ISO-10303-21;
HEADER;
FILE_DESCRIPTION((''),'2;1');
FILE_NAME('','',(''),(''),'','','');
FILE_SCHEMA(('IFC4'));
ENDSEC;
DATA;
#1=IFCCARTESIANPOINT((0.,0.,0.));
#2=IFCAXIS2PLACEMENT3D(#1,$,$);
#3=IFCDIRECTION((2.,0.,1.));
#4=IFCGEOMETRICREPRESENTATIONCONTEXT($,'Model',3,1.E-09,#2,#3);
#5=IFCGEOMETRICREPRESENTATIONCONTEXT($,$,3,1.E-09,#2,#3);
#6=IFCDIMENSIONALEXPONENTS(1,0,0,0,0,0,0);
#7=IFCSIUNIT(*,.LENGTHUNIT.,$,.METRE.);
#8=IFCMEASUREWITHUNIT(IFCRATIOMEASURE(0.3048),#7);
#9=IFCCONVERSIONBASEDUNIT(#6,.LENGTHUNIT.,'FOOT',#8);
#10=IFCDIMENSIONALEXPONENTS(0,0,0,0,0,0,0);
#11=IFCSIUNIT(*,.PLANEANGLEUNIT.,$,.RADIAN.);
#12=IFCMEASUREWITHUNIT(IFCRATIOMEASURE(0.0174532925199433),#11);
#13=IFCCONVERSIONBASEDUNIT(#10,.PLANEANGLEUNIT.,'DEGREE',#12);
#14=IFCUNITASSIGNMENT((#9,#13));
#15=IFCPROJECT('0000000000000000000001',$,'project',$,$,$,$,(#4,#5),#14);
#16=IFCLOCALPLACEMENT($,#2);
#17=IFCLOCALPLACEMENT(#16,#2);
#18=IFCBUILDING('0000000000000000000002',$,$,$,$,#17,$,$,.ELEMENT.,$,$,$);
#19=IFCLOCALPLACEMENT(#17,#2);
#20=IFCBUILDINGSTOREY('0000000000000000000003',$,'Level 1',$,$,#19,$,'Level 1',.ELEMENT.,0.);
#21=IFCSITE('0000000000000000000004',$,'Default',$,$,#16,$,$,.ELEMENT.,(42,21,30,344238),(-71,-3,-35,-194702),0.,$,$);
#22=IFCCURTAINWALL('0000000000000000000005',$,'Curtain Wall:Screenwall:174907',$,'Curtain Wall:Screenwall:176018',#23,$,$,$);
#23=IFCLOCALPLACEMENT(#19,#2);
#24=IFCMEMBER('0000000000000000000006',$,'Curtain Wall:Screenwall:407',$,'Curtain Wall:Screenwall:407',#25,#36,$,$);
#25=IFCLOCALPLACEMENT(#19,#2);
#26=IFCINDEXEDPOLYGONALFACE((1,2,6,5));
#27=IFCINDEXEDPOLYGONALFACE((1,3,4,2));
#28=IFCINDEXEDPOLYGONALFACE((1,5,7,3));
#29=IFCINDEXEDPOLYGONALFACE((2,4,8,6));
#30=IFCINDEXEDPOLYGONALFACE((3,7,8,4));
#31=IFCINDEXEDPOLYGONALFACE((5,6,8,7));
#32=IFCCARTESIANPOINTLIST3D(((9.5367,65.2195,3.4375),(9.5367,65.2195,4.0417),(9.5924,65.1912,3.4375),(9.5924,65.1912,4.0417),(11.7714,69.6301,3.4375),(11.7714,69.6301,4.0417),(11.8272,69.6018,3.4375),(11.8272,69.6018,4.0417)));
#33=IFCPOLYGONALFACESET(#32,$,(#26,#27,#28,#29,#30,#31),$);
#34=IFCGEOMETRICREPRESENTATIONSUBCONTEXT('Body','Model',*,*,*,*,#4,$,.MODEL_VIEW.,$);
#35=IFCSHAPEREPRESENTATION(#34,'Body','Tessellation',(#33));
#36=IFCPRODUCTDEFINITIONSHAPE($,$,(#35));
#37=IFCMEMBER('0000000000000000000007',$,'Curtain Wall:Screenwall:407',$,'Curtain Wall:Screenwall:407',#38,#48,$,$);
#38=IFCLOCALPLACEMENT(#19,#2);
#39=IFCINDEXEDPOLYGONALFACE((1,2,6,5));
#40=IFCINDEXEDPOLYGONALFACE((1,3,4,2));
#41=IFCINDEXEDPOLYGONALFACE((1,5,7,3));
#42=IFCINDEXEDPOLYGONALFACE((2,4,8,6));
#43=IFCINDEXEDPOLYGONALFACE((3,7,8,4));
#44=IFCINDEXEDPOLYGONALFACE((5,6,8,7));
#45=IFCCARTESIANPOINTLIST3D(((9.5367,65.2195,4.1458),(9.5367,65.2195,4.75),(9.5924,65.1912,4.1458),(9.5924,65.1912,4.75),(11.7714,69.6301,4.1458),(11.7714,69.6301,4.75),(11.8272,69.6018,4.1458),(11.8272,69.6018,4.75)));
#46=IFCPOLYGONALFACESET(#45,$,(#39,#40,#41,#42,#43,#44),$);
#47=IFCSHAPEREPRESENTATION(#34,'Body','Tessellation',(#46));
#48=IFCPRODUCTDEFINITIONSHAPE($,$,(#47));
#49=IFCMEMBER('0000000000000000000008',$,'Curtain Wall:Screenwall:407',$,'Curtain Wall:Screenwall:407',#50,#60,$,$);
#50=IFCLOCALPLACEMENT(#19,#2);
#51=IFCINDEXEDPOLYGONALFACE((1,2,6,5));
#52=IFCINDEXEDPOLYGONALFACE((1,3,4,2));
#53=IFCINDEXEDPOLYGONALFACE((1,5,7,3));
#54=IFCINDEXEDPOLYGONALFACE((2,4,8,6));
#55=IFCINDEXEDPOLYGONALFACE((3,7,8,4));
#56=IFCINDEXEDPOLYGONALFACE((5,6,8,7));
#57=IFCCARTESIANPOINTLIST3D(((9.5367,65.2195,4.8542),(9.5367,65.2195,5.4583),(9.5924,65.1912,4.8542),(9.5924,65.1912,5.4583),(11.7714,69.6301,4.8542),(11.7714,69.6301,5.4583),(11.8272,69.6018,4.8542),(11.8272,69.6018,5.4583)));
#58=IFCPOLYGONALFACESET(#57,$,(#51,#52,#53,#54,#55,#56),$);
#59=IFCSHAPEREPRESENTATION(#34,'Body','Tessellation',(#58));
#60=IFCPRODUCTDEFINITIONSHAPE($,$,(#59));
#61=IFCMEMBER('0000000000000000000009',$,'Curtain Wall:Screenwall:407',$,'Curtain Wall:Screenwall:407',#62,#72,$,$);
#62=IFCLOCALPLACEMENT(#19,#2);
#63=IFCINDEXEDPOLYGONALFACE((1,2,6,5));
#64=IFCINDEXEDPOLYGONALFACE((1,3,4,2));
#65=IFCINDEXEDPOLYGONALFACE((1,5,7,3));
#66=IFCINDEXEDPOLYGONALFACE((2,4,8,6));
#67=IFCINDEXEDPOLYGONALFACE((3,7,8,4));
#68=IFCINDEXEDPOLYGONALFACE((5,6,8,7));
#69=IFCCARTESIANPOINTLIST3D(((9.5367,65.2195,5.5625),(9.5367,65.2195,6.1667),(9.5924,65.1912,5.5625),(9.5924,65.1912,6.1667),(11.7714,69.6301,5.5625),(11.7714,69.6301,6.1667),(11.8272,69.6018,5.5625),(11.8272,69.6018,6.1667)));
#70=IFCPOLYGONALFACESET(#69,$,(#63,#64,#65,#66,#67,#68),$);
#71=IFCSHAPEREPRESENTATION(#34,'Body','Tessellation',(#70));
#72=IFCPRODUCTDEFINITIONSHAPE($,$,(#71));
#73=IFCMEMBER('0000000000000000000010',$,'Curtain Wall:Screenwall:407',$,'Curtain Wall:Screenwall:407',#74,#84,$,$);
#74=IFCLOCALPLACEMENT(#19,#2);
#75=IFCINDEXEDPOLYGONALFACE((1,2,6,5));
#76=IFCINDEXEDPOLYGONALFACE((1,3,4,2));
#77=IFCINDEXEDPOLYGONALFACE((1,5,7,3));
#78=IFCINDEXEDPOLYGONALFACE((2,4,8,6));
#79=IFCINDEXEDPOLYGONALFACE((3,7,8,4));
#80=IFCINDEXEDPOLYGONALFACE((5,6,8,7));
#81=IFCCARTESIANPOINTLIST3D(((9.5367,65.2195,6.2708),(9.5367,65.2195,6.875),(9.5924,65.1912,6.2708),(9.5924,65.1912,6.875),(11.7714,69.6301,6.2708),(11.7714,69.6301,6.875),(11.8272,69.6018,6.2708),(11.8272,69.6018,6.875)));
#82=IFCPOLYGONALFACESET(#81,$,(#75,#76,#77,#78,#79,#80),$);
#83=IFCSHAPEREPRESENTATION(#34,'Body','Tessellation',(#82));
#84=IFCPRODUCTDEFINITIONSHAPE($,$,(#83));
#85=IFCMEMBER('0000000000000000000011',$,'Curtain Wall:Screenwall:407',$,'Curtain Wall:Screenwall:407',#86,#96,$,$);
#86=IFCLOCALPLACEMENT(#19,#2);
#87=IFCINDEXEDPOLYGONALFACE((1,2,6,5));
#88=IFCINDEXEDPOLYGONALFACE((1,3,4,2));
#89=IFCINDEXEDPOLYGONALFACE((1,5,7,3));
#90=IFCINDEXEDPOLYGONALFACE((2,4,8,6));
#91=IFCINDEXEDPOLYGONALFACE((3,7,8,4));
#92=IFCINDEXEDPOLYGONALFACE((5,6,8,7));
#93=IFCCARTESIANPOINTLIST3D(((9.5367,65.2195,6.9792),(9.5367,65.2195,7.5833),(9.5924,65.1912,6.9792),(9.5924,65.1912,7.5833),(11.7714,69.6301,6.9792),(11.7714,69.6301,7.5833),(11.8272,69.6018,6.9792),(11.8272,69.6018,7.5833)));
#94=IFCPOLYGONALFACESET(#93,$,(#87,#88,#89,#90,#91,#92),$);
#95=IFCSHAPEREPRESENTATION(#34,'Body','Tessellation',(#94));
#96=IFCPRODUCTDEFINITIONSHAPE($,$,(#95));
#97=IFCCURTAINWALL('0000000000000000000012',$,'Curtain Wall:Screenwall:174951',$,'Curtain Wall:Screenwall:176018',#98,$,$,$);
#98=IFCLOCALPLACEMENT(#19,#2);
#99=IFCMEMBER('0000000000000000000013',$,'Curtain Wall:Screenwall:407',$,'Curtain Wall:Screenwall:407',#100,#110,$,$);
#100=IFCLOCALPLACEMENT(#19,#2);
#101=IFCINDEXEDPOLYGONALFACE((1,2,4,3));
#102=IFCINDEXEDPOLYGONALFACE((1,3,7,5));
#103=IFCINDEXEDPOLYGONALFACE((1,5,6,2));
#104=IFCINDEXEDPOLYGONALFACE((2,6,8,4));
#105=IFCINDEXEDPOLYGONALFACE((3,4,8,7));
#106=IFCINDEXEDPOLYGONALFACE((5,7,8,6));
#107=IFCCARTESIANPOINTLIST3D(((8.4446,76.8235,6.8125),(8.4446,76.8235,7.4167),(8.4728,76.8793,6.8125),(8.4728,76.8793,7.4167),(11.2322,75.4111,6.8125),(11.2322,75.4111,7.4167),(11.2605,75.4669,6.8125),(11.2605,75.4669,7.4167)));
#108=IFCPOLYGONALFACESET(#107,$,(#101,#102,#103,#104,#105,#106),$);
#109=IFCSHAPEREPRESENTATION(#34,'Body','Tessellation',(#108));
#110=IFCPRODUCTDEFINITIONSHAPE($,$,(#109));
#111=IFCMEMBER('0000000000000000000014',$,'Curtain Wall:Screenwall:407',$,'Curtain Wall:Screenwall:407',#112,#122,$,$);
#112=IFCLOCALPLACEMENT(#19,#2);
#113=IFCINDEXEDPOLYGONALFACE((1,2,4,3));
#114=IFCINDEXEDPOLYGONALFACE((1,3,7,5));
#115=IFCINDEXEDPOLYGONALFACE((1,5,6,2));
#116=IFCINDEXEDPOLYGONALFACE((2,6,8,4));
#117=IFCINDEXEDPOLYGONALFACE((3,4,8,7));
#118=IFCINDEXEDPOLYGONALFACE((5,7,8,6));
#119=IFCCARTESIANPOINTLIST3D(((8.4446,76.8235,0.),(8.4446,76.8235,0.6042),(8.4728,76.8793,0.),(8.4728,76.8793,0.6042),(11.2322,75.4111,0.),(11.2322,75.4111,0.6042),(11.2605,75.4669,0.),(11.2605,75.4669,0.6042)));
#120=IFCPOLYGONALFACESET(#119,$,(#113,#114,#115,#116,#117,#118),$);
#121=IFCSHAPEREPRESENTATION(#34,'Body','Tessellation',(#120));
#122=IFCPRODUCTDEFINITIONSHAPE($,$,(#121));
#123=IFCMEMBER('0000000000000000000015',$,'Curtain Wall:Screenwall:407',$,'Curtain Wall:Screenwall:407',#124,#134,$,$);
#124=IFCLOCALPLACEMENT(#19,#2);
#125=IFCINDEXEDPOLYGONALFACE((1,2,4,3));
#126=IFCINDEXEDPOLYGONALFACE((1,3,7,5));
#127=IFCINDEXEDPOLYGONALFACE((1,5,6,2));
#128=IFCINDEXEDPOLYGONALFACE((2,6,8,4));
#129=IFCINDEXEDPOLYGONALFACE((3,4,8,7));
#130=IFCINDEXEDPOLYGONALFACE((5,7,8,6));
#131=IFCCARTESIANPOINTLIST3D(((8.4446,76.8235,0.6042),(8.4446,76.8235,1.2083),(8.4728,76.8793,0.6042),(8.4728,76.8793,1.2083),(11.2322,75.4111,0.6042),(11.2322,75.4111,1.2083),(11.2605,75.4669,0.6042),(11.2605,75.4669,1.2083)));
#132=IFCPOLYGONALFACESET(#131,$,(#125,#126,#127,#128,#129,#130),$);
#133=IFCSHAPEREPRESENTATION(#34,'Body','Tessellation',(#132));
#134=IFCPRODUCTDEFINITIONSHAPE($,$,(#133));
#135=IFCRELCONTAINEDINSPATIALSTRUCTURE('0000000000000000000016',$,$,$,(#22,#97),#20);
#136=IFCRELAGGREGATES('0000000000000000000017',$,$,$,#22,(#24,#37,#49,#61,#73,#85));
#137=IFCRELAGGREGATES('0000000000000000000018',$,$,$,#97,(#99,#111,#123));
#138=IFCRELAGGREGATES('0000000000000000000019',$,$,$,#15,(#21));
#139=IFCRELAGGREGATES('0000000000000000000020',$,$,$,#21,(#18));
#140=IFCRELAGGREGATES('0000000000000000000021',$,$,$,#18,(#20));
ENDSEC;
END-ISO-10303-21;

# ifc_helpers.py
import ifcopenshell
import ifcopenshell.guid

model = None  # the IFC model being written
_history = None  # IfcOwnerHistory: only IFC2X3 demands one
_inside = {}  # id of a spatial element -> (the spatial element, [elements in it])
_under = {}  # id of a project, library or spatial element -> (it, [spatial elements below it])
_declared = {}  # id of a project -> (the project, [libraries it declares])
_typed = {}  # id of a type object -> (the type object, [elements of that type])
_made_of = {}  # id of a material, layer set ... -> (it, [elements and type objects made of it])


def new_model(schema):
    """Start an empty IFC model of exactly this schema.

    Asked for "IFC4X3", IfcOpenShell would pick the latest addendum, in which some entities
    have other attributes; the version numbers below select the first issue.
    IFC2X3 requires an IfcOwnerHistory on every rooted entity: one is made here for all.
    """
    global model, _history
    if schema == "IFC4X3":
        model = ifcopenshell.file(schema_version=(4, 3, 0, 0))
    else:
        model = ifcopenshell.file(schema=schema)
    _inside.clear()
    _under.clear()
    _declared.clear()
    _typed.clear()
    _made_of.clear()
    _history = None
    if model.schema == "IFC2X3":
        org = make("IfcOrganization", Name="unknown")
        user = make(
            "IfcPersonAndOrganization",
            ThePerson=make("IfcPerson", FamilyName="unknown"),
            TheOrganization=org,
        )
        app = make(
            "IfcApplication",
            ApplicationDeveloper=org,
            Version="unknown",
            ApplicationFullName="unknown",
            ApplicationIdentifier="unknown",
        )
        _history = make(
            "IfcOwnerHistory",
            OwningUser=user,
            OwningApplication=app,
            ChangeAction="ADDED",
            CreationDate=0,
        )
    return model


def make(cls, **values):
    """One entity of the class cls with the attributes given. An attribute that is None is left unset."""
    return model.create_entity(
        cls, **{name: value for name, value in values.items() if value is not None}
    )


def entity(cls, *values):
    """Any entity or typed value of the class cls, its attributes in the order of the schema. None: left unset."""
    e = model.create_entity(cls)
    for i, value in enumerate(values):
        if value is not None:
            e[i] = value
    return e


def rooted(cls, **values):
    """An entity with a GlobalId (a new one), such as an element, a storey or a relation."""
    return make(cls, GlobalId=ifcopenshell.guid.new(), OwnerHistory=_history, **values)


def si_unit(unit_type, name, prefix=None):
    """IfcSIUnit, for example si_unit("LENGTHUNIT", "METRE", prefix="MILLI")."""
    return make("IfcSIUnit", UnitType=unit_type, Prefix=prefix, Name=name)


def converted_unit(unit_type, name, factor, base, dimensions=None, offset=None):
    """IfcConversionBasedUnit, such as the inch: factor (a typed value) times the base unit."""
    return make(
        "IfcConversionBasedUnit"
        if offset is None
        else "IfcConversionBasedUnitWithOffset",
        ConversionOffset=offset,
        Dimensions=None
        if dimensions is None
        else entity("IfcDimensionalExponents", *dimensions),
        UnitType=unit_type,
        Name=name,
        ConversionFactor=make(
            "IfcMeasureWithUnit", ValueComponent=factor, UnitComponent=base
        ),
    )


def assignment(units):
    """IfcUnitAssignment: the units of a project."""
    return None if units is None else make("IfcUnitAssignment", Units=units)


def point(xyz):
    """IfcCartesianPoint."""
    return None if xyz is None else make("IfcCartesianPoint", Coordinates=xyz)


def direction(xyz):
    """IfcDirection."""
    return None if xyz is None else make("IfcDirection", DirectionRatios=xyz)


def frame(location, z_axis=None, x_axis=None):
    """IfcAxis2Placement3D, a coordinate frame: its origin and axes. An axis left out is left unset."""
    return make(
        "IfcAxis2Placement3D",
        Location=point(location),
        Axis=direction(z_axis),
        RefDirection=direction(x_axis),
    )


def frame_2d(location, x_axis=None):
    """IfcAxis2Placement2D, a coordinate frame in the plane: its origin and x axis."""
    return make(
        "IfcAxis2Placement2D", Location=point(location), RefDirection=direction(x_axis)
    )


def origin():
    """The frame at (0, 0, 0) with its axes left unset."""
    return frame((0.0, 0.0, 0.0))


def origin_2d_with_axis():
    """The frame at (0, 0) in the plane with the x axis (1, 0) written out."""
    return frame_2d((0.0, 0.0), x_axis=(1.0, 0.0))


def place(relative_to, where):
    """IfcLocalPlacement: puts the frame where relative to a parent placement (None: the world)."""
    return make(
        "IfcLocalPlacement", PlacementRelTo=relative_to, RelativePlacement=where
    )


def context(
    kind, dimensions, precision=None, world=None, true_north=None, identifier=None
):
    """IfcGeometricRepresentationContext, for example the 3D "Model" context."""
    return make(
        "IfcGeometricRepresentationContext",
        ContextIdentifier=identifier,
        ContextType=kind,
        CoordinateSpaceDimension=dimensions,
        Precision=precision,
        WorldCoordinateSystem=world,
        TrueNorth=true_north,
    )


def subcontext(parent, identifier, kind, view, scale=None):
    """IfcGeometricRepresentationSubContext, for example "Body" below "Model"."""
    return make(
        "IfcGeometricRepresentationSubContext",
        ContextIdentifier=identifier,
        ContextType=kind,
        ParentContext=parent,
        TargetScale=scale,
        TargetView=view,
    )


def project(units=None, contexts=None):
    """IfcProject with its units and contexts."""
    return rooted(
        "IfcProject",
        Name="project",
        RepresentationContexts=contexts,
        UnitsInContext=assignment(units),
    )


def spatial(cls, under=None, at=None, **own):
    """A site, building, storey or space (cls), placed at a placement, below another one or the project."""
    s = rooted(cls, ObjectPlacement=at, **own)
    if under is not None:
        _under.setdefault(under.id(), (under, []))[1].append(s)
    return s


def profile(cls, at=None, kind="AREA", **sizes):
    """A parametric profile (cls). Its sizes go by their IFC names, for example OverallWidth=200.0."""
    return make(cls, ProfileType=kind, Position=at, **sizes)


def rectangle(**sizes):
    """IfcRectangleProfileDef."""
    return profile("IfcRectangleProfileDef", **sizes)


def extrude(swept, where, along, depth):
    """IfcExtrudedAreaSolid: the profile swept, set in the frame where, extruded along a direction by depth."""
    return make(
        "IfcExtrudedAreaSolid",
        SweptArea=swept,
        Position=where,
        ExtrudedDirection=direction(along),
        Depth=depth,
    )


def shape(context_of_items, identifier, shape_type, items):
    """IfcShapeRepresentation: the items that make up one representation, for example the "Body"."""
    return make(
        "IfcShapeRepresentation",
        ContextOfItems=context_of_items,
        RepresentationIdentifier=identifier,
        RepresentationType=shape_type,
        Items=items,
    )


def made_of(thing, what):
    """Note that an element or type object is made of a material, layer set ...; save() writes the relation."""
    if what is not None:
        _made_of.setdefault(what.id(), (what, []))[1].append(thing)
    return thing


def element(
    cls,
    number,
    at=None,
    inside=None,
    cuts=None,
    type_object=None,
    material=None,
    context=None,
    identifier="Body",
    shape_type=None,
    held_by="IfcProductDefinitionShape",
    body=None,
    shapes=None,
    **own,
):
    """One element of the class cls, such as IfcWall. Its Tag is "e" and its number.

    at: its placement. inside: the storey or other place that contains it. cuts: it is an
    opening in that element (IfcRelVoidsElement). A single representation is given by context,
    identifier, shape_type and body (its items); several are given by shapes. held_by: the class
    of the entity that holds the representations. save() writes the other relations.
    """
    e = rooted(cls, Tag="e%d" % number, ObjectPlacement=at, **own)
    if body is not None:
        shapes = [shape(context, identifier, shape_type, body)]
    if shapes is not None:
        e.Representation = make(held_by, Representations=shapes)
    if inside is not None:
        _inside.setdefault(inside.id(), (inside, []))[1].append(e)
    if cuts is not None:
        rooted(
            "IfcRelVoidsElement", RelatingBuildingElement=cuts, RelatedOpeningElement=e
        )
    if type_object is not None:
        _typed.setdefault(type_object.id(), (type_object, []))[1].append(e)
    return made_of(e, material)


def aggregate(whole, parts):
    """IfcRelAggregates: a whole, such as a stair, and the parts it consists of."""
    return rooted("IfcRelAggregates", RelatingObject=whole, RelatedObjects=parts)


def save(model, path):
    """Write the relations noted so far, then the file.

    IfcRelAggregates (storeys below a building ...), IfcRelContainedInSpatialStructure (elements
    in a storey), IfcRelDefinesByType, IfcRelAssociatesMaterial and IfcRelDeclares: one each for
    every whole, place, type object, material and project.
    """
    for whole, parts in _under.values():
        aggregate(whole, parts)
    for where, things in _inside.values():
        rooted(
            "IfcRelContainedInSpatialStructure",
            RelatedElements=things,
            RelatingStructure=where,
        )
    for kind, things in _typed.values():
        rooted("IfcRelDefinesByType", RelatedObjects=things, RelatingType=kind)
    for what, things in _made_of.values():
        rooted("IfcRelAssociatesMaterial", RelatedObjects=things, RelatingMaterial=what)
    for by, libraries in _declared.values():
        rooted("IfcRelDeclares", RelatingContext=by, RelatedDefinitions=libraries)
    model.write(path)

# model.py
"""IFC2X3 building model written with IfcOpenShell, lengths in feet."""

from ifc_helpers import new_model, entity, si_unit, converted_unit, direction, frame, frame_2d, origin, origin_2d_with_axis, place, context, subcontext, project, spatial, rectangle, extrude, element, aggregate, save


model = new_model("IFC2X3")

# Units and contexts
model_context = context("Model", 3, precision=1e-09, world=origin(), true_north=direction((2.0, 0.0, 1.0)))
context_of_model = context(None, 3, precision=1e-09, world=origin(), true_north=direction((2.0, 0.0, 1.0)))
body_context = subcontext(model_context, "Body", "Model", "MODEL_VIEW")
ifc_project = project(units=[converted_unit("LENGTHUNIT", "FOOT", entity("IfcRatioMeasure", 0.3048), si_unit("LENGTHUNIT", "METRE"), dimensions=[1, 0, 0, 0, 0, 0, 0]), converted_unit("PLANEANGLEUNIT", "DEGREE", entity("IfcRatioMeasure", 0.0174532925199433), si_unit("PLANEANGLEUNIT", "RADIAN"), dimensions=[0, 0, 0, 0, 0, 0, 0])], contexts=[model_context, context_of_model])

# Site, building, storey
site_placement = place(None, origin())
site = spatial("IfcSite", under=ifc_project, at=site_placement, Name="Default", CompositionType="ELEMENT", RefLatitude=(42, 21, 30, 344238), RefLongitude=(-71, -3, -35, -194702), RefElevation=0.0)
building_placement = place(site_placement, origin())
building = spatial("IfcBuilding", under=site, at=building_placement, CompositionType="ELEMENT")
storey_placement = place(building_placement, origin())
storey = spatial("IfcBuildingStorey", under=building, at=storey_placement, Name="Level 1", LongName="Level 1", CompositionType="ELEMENT", Elevation=0.0)

# Curtain walls, members
curtain_wall_1_placement = place(storey_placement, origin())
curtain_wall_1 = element("IfcCurtainWall", 1, at=curtain_wall_1_placement, inside=storey, Name="Curtain Wall:Screenwall:174907", ObjectType="Curtain Wall:Screenwall:176018")
member_1_placement = place(curtain_wall_1_placement, frame((9.5367, 65.1912, 3.4375)))
member_1 = element("IfcMember", 2, at=member_1_placement, Name="Curtain Wall:Screenwall:407", ObjectType="Curtain Wall:Screenwall:407", context=body_context, shape_type="SweptSolid", body=[
    extrude(rectangle(XDim=4.9444, YDim=0.0625, at=frame_2d((0.0, 0.0), x_axis=(1.0, 0.0))), frame((1.1452, 2.2194, 0.0), z_axis=(0.0, 0.0, 1.0), x_axis=(-0.451968, -0.892034, 0.0)), (0.0, 0.0, 1.0), 0.6042),
])
member_2_placement = place(curtain_wall_1_placement, frame((9.5367, 65.1912, 4.1458)))
member_2 = element("IfcMember", 3, at=member_2_placement, Name="Curtain Wall:Screenwall:407", ObjectType="Curtain Wall:Screenwall:407", context=body_context, shape_type="SweptSolid", body=[
    extrude(rectangle(XDim=4.9444, YDim=0.0625, at=frame_2d((0.0, 0.0), x_axis=(1.0, 0.0))), frame((1.1452, 2.2194, 0.0), z_axis=(0.0, 0.0, 1.0), x_axis=(-0.451968, -0.892034, 0.0)), (0.0, 0.0, 1.0), 0.6042),
])
member_3_placement = place(curtain_wall_1_placement, frame((9.5367, 65.1912, 4.8542)))
member_3 = element("IfcMember", 4, at=member_3_placement, Name="Curtain Wall:Screenwall:407", ObjectType="Curtain Wall:Screenwall:407", context=body_context, shape_type="SweptSolid", body=[
    extrude(rectangle(XDim=4.9444, YDim=0.0625, at=frame_2d((0.0, 0.0), x_axis=(1.0, 0.0))), frame((1.1452, 2.2194, 0.0), z_axis=(0.0, 0.0, 1.0), x_axis=(-0.451968, -0.892034, 0.0)), (0.0, 0.0, 1.0), 0.6042),
])
member_4_placement = place(curtain_wall_1_placement, frame((9.5367, 65.1912, 5.5625)))
member_4 = element("IfcMember", 5, at=member_4_placement, Name="Curtain Wall:Screenwall:407", ObjectType="Curtain Wall:Screenwall:407", context=body_context, shape_type="SweptSolid", body=[
    extrude(rectangle(XDim=4.9444, YDim=0.0625, at=frame_2d((0.0, 0.0), x_axis=(1.0, 0.0))), frame((1.1452, 2.2194, 0.0), z_axis=(0.0, 0.0, 1.0), x_axis=(-0.451968, -0.892034, 0.0)), (0.0, 0.0, 1.0), 0.6042),
])
member_5_placement = place(curtain_wall_1_placement, frame((9.5367, 65.1912, 6.2708)))
member_5 = element("IfcMember", 6, at=member_5_placement, Name="Curtain Wall:Screenwall:407", ObjectType="Curtain Wall:Screenwall:407", context=body_context, shape_type="SweptSolid", body=[
    extrude(rectangle(XDim=4.9444, YDim=0.0625, at=frame_2d((0.0, 0.0), x_axis=(1.0, 0.0))), frame((1.1452, 2.2194, 0.0), z_axis=(0.0, 0.0, 1.0), x_axis=(-0.451968, -0.892034, 0.0)), (0.0, 0.0, 1.0), 0.6042),
])
member_6_placement = place(curtain_wall_1_placement, frame((9.5367, 65.1912, 6.9792)))
member_6 = element("IfcMember", 7, at=member_6_placement, Name="Curtain Wall:Screenwall:407", ObjectType="Curtain Wall:Screenwall:407", context=body_context, shape_type="SweptSolid", body=[
    extrude(rectangle(XDim=4.9444, YDim=0.0625, at=frame_2d((0.0, 0.0), x_axis=(1.0, 0.0))), frame((1.1452, 2.2194, 0.0), z_axis=(0.0, 0.0, 1.0), x_axis=(-0.451968, -0.892034, 0.0)), (0.0, 0.0, 1.0), 0.6042),
])
aggregate(curtain_wall_1, [member_1, member_2, member_3, member_4, member_5, member_6])
curtain_wall_2_placement = place(storey_placement, origin())
curtain_wall_2 = element("IfcCurtainWall", 8, at=curtain_wall_2_placement, inside=storey, Name="Curtain Wall:Screenwall:174951", ObjectType="Curtain Wall:Screenwall:176018")
member_7_placement = place(curtain_wall_2_placement, frame((8.4446, 75.4111, 6.8125)))
member_7 = element("IfcMember", 9, at=member_7_placement, Name="Curtain Wall:Screenwall:407", ObjectType="Curtain Wall:Screenwall:407", context=body_context, shape_type="SweptSolid", body=[
    extrude(rectangle(XDim=3.1251, YDim=0.0625, at=frame_2d((0.0, 0.0), x_axis=(1.0, 0.0))), frame((1.408, 0.7341, 0.0), z_axis=(0.0, 0.0, 1.0), x_axis=(0.892035, -0.451966, 0.0)), (0.0, 0.0, 1.0), 0.6042),
])
member_8_placement = place(curtain_wall_2_placement, frame((8.4446, 75.4111, 0.0)))
member_8 = element("IfcMember", 10, at=member_8_placement, Name="Curtain Wall:Screenwall:407", ObjectType="Curtain Wall:Screenwall:407", context=body_context, shape_type="SweptSolid", body=[
    extrude(rectangle(XDim=3.1251, YDim=0.0625, at=origin_2d_with_axis()), frame((1.408, 0.7341, 0.0), z_axis=(0.0, 0.0, 1.0), x_axis=(-0.892035, 0.451966, 0.0)), (0.0, 0.0, 1.0), 0.6042),
])
member_9_placement = place(curtain_wall_2_placement, frame((8.4446, 75.4111, 0.6042)))
member_9 = element("IfcMember", 11, at=member_9_placement, Name="Curtain Wall:Screenwall:407", ObjectType="Curtain Wall:Screenwall:407", context=body_context, shape_type="SweptSolid", body=[
    extrude(rectangle(XDim=3.1251, YDim=0.0625, at=frame_2d((0.0, 0.0), x_axis=(1.0, 0.0))), frame((1.408, 0.7341, 0.0), z_axis=(0.0, 0.0, 1.0), x_axis=(0.892035, -0.451966, 0.0)), (0.0, 0.0, 1.0), 0.6042),
])
aggregate(curtain_wall_2, [member_7, member_8, member_9])

save(model, "model.ifc")
